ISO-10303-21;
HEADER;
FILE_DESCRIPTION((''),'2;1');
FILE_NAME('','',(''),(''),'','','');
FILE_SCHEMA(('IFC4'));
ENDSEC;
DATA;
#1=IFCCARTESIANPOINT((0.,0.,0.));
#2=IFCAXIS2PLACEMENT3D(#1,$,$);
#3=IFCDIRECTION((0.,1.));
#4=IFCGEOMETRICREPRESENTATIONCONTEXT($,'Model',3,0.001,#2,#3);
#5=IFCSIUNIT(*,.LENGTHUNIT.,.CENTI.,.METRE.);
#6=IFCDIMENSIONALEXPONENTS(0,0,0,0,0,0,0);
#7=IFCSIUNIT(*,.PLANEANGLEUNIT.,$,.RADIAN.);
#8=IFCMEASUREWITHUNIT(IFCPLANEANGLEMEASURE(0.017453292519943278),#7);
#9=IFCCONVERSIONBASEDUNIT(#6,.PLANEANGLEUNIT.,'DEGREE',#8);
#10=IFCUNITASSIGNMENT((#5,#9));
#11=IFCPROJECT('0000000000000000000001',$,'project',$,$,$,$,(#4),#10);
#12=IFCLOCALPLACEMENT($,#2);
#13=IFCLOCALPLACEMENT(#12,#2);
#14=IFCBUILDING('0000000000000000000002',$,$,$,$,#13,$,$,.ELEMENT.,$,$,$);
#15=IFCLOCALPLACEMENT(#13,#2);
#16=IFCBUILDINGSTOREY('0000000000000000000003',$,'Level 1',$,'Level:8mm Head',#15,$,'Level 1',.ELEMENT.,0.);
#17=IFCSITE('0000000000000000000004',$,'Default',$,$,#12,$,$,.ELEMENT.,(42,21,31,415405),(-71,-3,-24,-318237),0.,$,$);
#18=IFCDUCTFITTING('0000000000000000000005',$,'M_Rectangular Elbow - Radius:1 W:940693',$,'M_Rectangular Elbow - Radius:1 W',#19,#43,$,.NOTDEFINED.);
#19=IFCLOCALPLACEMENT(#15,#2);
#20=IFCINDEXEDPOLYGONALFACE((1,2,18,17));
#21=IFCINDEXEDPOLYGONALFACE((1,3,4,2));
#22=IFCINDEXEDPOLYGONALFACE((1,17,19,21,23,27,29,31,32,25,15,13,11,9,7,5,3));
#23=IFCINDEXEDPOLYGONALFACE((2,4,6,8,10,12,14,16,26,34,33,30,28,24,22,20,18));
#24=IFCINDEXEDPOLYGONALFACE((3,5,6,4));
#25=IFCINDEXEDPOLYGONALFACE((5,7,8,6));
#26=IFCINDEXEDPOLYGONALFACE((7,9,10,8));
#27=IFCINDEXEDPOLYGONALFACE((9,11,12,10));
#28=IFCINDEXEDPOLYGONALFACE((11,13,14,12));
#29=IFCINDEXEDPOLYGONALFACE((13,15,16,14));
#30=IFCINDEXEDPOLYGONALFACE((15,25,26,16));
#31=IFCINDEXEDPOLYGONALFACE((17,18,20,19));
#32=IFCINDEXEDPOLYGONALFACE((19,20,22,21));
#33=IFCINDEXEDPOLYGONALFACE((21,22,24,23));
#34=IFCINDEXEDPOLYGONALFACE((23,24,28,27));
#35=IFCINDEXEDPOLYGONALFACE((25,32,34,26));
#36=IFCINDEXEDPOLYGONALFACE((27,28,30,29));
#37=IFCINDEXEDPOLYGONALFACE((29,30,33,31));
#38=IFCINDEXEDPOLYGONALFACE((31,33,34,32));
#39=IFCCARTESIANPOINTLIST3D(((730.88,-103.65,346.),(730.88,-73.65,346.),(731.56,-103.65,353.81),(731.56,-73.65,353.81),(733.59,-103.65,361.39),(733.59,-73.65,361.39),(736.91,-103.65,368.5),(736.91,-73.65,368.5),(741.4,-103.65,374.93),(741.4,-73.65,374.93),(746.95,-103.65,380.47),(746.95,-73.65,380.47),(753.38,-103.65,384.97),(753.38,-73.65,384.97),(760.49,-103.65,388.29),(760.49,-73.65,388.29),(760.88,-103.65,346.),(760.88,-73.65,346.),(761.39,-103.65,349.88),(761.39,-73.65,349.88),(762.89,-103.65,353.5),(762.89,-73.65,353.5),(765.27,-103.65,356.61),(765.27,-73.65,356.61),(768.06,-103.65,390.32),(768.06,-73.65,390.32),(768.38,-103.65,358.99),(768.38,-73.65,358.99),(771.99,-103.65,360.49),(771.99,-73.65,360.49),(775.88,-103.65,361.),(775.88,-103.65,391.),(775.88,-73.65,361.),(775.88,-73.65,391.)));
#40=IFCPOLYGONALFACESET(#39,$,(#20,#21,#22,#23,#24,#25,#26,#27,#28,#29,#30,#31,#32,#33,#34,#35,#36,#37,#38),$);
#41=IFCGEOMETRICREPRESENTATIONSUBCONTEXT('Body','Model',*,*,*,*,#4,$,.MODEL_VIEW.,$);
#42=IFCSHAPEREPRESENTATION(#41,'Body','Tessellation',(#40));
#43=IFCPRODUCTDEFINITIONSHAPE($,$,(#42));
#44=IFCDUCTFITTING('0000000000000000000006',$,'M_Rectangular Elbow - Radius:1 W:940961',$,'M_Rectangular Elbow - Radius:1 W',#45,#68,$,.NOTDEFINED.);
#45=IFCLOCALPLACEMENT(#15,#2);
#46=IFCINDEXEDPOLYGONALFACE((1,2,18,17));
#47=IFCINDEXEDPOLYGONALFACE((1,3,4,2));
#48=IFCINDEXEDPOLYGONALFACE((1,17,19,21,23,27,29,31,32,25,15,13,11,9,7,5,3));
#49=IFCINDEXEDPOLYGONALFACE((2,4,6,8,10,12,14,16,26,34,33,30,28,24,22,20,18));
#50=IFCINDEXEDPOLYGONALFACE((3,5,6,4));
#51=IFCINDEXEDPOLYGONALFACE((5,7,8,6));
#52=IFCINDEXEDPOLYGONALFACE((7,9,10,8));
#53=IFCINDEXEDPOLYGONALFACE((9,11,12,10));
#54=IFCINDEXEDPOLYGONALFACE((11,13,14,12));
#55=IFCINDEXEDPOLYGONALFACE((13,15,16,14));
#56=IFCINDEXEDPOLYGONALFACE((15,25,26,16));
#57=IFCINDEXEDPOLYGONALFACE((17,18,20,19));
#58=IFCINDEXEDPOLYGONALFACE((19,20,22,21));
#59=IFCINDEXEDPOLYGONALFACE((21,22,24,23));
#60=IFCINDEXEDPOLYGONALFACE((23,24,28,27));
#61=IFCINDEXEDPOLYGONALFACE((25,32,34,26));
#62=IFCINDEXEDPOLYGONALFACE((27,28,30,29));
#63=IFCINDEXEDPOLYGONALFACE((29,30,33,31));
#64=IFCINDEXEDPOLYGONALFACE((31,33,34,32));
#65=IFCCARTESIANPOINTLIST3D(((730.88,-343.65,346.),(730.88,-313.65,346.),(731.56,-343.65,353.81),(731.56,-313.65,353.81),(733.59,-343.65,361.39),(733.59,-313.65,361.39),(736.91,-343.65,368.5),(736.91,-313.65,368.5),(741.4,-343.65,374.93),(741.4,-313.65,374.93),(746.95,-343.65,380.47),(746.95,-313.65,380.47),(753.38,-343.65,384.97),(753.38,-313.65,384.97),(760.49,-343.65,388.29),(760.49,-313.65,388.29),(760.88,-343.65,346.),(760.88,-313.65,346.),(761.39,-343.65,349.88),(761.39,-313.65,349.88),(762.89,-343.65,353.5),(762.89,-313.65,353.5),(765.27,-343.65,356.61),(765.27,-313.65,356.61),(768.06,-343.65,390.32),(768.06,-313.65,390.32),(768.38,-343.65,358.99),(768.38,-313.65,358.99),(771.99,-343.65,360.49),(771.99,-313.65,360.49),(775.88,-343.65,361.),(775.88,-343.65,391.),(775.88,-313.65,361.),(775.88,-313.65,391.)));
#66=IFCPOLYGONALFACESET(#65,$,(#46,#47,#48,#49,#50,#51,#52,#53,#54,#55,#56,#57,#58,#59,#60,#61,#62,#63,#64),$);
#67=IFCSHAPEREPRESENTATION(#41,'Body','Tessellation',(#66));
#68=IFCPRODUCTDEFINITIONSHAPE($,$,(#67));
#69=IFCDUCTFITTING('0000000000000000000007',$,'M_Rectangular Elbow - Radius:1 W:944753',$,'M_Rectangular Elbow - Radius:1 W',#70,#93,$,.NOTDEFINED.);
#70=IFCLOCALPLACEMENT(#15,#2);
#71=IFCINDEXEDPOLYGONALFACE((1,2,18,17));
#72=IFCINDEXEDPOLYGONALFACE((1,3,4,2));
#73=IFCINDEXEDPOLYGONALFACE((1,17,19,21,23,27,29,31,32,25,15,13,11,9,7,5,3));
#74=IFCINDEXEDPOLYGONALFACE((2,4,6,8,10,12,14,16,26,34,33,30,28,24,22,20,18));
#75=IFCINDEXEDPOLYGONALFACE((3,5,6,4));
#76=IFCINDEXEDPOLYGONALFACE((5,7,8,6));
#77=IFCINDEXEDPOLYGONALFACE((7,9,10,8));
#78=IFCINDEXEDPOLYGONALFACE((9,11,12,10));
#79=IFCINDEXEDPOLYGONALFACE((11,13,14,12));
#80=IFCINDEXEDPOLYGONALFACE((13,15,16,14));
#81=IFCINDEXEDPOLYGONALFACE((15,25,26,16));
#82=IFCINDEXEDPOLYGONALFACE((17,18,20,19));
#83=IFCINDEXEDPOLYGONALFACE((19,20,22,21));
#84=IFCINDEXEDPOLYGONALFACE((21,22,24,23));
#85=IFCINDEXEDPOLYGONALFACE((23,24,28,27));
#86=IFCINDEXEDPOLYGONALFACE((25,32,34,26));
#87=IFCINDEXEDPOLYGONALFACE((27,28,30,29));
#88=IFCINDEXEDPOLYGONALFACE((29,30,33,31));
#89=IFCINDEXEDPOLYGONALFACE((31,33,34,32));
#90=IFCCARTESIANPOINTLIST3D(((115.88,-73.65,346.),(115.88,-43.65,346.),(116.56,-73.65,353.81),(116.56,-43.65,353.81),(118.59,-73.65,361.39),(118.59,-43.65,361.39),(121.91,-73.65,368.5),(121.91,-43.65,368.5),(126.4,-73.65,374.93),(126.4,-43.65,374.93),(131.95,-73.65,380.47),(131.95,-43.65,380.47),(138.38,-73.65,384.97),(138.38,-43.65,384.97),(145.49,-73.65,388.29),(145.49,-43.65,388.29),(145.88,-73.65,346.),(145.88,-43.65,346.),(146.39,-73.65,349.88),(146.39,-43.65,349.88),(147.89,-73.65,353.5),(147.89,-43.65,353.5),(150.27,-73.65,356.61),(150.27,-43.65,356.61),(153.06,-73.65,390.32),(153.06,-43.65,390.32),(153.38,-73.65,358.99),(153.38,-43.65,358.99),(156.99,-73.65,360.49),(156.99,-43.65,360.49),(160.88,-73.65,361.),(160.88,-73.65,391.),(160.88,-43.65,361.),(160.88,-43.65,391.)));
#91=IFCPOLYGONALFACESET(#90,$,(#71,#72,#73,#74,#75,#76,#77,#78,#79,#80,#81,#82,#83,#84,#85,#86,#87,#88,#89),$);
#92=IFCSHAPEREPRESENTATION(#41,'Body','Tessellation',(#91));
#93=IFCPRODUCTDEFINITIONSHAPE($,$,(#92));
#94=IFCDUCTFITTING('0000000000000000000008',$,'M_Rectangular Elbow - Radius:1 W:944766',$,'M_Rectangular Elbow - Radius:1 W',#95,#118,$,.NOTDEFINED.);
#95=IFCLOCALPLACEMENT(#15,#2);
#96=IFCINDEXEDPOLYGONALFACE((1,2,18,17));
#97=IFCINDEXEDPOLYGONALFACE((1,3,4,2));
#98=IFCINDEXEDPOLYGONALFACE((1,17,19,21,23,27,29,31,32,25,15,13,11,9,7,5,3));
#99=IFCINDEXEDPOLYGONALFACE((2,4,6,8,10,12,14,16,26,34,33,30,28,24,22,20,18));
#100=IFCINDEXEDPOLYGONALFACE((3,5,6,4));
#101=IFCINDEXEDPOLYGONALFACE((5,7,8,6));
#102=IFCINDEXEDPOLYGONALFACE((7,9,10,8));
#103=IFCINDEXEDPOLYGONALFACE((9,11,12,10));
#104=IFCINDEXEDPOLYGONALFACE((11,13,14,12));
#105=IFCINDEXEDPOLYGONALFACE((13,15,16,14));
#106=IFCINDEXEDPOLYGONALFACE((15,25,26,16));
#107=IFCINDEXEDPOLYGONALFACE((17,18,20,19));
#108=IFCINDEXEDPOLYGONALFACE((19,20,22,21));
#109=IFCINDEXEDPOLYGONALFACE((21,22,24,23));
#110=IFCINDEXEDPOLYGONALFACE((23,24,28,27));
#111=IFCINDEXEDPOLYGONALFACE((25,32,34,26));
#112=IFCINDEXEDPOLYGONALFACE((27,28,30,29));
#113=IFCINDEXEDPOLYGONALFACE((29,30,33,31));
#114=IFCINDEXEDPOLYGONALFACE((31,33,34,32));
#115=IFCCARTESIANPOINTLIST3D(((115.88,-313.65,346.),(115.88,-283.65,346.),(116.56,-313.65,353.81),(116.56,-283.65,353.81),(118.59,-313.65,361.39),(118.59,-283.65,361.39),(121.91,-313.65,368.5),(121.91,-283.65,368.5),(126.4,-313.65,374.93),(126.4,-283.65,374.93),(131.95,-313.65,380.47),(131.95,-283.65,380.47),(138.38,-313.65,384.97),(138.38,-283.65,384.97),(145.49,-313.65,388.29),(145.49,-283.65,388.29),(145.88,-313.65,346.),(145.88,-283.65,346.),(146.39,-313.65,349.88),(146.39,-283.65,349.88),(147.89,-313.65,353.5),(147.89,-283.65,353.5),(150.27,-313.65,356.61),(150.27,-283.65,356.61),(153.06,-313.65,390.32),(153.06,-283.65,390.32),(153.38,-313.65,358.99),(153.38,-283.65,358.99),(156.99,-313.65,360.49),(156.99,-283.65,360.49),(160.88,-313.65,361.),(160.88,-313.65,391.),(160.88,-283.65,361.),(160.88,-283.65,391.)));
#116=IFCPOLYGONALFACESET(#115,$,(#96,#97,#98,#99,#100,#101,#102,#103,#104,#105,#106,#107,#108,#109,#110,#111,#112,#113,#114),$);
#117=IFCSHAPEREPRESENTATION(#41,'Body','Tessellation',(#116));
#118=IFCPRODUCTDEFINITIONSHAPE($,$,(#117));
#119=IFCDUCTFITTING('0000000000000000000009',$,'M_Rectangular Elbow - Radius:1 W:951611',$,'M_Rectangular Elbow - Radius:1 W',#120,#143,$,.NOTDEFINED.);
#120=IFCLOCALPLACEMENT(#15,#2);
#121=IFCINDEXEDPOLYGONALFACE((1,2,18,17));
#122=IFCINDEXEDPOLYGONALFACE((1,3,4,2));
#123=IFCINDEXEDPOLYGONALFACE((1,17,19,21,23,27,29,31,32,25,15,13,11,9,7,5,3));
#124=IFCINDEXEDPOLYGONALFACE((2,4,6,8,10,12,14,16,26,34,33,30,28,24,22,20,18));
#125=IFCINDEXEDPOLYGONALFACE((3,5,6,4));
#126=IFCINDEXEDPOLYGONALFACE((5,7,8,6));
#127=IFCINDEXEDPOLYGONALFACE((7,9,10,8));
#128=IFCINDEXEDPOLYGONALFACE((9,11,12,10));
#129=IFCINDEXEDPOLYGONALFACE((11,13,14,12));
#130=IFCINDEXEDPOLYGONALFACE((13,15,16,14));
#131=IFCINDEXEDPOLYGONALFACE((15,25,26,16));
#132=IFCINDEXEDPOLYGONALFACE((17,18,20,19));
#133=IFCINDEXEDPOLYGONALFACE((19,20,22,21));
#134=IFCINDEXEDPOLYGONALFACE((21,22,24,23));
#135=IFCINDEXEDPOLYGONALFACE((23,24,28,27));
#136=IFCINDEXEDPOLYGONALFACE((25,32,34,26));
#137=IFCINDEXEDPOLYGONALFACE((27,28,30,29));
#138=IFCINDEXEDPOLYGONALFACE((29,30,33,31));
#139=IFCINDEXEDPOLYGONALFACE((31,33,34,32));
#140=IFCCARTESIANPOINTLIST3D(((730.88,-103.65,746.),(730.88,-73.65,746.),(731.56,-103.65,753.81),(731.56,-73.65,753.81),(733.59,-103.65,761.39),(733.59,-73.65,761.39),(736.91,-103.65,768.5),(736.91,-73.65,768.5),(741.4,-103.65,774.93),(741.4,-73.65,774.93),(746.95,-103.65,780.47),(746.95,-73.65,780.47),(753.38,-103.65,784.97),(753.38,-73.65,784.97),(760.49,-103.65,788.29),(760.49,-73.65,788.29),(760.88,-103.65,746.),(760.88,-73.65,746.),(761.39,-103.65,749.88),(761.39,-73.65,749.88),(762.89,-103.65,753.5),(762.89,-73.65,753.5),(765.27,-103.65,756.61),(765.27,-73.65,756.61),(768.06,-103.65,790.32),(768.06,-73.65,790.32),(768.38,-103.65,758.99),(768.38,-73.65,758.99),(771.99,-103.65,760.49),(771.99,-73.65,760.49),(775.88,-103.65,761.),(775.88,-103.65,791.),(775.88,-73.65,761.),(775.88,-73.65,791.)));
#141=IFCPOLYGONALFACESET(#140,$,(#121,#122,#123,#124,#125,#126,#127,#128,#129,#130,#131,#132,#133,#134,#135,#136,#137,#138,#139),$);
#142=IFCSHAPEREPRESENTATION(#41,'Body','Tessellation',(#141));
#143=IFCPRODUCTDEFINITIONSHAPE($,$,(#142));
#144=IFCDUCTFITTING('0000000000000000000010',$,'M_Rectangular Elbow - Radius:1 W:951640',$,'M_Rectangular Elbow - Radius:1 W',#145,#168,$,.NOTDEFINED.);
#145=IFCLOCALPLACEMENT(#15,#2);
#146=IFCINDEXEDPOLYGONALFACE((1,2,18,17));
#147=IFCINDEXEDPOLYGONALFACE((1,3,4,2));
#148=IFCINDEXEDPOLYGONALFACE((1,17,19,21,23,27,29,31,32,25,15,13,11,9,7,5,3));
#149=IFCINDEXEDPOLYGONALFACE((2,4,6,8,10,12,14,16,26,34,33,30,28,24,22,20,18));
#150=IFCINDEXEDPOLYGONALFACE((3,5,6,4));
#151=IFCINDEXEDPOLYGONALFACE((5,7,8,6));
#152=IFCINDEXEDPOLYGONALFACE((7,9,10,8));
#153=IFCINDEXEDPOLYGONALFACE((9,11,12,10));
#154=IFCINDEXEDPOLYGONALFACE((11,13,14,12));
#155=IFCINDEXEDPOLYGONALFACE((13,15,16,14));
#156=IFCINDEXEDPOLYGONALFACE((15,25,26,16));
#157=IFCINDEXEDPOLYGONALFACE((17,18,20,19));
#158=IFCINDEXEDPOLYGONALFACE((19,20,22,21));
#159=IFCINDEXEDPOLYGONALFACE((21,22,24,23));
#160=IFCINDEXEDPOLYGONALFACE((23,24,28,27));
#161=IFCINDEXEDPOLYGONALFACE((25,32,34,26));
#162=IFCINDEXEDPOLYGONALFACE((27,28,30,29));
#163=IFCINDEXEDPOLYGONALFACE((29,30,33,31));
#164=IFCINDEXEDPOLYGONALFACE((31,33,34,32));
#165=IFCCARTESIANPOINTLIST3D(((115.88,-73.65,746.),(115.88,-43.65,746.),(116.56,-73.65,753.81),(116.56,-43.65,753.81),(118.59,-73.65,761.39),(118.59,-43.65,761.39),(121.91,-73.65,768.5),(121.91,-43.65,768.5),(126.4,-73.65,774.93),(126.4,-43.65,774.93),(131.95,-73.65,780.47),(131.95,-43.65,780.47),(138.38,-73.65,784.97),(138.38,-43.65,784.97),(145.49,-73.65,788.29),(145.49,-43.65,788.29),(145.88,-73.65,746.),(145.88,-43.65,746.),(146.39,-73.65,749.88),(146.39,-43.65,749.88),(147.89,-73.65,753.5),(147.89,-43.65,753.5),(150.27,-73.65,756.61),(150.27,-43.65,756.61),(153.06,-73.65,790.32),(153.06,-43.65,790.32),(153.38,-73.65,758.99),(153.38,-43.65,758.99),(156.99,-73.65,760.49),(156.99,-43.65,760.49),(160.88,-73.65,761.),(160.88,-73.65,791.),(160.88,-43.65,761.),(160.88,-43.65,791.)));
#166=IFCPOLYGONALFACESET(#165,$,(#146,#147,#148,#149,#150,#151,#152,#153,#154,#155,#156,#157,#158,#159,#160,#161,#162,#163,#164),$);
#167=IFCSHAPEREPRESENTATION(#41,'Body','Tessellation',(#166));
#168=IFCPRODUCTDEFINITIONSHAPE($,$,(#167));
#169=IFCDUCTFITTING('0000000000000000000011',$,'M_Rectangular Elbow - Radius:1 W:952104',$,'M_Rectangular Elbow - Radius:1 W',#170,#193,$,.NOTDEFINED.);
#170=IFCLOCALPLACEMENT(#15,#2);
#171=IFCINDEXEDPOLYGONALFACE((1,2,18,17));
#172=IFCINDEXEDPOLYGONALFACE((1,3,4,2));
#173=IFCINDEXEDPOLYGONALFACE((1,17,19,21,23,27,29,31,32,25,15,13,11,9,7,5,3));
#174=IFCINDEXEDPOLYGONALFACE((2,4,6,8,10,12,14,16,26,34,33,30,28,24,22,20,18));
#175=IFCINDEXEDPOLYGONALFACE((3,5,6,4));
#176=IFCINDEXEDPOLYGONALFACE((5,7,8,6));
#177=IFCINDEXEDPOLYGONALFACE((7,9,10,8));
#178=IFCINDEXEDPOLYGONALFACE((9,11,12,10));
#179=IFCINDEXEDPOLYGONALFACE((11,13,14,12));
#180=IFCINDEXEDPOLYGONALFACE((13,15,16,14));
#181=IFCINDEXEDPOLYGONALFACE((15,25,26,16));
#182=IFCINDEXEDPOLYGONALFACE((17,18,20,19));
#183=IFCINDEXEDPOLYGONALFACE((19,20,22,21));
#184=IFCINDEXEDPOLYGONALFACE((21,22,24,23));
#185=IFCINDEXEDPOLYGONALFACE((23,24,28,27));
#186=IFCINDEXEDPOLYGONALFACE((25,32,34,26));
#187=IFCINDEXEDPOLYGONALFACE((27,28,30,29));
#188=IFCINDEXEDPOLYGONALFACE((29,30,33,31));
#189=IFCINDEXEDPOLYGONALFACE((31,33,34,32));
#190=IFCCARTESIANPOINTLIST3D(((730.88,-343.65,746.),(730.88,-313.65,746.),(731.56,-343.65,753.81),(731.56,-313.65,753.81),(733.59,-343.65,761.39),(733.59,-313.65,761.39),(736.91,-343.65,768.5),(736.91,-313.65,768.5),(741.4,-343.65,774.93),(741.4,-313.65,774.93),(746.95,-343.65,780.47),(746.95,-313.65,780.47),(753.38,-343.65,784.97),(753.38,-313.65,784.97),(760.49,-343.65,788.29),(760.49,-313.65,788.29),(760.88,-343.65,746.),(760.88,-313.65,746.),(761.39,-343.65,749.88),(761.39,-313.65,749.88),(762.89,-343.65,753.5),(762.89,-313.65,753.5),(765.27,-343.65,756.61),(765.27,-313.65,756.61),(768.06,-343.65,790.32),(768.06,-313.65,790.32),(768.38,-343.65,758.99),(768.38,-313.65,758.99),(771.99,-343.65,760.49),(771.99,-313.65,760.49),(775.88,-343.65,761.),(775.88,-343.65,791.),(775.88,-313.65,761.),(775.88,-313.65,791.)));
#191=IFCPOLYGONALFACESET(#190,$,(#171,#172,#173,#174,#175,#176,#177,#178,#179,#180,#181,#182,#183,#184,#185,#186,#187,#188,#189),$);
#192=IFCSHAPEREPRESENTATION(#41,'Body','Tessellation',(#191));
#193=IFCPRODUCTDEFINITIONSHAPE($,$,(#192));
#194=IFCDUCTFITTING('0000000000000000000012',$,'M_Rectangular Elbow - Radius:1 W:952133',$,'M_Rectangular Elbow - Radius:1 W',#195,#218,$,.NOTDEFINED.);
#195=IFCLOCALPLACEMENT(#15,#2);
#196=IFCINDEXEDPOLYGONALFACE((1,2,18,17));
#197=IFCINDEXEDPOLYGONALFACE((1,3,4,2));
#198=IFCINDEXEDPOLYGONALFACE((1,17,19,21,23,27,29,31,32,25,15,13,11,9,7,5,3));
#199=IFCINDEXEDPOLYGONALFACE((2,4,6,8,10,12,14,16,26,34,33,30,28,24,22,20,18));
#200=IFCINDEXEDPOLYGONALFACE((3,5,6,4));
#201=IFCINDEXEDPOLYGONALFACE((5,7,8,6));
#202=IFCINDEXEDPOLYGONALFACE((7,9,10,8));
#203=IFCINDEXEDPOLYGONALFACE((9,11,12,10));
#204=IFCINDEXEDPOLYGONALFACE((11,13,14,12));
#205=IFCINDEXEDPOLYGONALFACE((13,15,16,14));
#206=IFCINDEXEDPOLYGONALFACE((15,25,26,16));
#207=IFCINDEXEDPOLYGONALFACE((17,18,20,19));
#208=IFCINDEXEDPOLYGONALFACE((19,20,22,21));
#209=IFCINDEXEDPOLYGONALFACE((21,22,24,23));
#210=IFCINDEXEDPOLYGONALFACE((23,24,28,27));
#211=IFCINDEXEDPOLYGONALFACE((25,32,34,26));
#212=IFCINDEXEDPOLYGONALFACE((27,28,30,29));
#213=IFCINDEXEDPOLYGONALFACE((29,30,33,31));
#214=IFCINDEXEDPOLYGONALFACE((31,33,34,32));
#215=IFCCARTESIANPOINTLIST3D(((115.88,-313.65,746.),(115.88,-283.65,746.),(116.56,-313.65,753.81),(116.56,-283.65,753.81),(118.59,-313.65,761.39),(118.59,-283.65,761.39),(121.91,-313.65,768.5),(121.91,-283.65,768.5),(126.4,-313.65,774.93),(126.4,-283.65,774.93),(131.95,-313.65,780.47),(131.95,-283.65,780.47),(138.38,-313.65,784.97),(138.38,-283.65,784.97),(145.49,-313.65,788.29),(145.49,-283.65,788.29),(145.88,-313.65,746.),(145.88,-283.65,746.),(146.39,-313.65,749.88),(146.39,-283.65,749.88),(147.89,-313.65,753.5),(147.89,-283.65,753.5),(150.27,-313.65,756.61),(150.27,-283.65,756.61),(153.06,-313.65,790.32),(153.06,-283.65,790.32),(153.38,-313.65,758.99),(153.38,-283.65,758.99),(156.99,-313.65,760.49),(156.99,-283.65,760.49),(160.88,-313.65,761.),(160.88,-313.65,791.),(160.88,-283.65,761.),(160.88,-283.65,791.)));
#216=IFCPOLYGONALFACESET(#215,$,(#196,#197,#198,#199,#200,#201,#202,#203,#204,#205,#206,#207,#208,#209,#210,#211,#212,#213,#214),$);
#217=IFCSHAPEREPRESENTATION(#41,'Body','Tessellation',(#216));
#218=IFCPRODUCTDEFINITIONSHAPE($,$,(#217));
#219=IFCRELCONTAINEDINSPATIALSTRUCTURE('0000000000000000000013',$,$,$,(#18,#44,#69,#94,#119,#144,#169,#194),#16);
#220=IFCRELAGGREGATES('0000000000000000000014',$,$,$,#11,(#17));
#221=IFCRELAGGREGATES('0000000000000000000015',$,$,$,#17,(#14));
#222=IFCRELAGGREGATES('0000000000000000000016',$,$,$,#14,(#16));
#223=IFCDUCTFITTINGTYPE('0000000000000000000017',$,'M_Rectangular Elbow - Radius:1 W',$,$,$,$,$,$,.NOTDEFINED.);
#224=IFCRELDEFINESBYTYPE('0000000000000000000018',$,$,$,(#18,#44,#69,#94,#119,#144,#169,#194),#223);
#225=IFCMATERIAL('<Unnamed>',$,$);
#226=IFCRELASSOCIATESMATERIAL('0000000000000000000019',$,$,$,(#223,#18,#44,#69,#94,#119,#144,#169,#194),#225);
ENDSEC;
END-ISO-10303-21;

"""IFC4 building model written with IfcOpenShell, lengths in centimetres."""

from ifc_helpers import new_model, entity, si_unit, converted_unit, direction, frame, origin, place, context, subcontext, project, spatial, line, arc, indexed_curve, outline, extrude, source, transform, mapped, material, type_object, type_shapes, element, save


model = new_model("IFC4")

# Units and contexts
model_context = context("Model", 3, precision=0.001, world=origin(), true_north=direction((0.0, 1.0)))
body_context = subcontext(model_context, "Body", "Model", "MODEL_VIEW")
ifc_project = project(units=[si_unit("LENGTHUNIT", "METRE", prefix="CENTI"), converted_unit("PLANEANGLEUNIT", "DEGREE", entity("IfcPlaneAngleMeasure", 0.017453292519943278), si_unit("PLANEANGLEUNIT", "RADIAN"), dimensions=[0, 0, 0, 0, 0, 0, 0])], contexts=[model_context])

# Site, building, storey
site_placement = place(None, origin())
site = spatial("IfcSite", under=ifc_project, at=site_placement, Name="Default", CompositionType="ELEMENT", RefLatitude=(42, 21, 31, 415405), RefLongitude=(-71, -3, -24, -318237), RefElevation=0.0)
building_placement = place(site_placement, origin())
building = spatial("IfcBuilding", under=site, at=building_placement, CompositionType="ELEMENT")
storey_placement = place(building_placement, origin())
storey = spatial("IfcBuildingStorey", under=building, at=storey_placement, Name="Level 1", ObjectType="Level:8mm Head", LongName="Level 1", CompositionType="ELEMENT", Elevation=0.0)

# Duct fittings
ifc_material = material(Name="<Unnamed>")
duct_fitting_type_1 = type_object("IfcDuctFittingType", Name="M_Rectangular Elbow - Radius:1 W", PredefinedType="NOTDEFINED", material=ifc_material)
shared_shape_1 = source(origin(), body_context, "Body", "SweptSolid", [
    extrude(outline(indexed_curve([(-30.0, -15.0), (0.0, -15.0), (4.39, -4.39), (15.0, 0.0), (15.0, 30.0), (-16.82, 16.82)], segments=[line(1, 2), arc(2, 3, 4), line(4, 5), arc(5, 6, 1)], self_intersect=False)), frame((-15.0, 15.0, -15.0), z_axis=(0.0, 0.0, 1.0), x_axis=(-1.0, 0.0, 0.0)), (0.0, 0.0, 1.0), 30.0),
])
type_shapes(duct_fitting_type_1, [shared_shape_1])
for number, where, z_axis, x_axis, name in (
    (1, (745.88, -88.65, 376.0), (0.0, -1.0, 0.0), (-1.0, 0.0, 0.0), "M_Rectangular Elbow - Radius:1 W:940693"),
    (2, (745.88, -328.65, 376.0), (0.0, -1.0, 0.0), (-1.0, 0.0, 0.0), "M_Rectangular Elbow - Radius:1 W:940961"),
    (3, (130.88, -58.65, 376.0), (0.0, 1.0, 0.0), (0.0, 0.0, 1.0), "M_Rectangular Elbow - Radius:1 W:944753"),
    (4, (130.88, -298.65, 376.0), (0.0, 1.0, 0.0), (0.0, 0.0, 1.0), "M_Rectangular Elbow - Radius:1 W:944766"),
    (5, (745.88, -88.65, 776.0), (0.0, -1.0, 0.0), (-1.0, 0.0, 0.0), "M_Rectangular Elbow - Radius:1 W:951611"),
    (6, (130.88, -58.65, 776.0), (0.0, -1.0, 0.0), (-1.0, 0.0, 0.0), "M_Rectangular Elbow - Radius:1 W:951640"),
    (7, (745.88, -328.65, 776.0), (0.0, -1.0, 0.0), (-1.0, 0.0, 0.0), "M_Rectangular Elbow - Radius:1 W:952104"),
    (8, (130.88, -298.65, 776.0), (0.0, -1.0, 0.0), (-1.0, 0.0, 0.0), "M_Rectangular Elbow - Radius:1 W:952133"),
):
    element("IfcDuctFitting", number, at=place(storey_placement, frame(where, z_axis=z_axis, x_axis=x_axis)), inside=storey, type_object=duct_fitting_type_1, material=ifc_material, Name=name, ObjectType="M_Rectangular Elbow - Radius:1 W", PredefinedType="NOTDEFINED", context=body_context, shape_type="MappedRepresentation", body=[
        mapped(shared_shape_1, transform((0.0, 0.0, 0.0), scale=1.0)),
    ])

save(model, "model.ifc")
